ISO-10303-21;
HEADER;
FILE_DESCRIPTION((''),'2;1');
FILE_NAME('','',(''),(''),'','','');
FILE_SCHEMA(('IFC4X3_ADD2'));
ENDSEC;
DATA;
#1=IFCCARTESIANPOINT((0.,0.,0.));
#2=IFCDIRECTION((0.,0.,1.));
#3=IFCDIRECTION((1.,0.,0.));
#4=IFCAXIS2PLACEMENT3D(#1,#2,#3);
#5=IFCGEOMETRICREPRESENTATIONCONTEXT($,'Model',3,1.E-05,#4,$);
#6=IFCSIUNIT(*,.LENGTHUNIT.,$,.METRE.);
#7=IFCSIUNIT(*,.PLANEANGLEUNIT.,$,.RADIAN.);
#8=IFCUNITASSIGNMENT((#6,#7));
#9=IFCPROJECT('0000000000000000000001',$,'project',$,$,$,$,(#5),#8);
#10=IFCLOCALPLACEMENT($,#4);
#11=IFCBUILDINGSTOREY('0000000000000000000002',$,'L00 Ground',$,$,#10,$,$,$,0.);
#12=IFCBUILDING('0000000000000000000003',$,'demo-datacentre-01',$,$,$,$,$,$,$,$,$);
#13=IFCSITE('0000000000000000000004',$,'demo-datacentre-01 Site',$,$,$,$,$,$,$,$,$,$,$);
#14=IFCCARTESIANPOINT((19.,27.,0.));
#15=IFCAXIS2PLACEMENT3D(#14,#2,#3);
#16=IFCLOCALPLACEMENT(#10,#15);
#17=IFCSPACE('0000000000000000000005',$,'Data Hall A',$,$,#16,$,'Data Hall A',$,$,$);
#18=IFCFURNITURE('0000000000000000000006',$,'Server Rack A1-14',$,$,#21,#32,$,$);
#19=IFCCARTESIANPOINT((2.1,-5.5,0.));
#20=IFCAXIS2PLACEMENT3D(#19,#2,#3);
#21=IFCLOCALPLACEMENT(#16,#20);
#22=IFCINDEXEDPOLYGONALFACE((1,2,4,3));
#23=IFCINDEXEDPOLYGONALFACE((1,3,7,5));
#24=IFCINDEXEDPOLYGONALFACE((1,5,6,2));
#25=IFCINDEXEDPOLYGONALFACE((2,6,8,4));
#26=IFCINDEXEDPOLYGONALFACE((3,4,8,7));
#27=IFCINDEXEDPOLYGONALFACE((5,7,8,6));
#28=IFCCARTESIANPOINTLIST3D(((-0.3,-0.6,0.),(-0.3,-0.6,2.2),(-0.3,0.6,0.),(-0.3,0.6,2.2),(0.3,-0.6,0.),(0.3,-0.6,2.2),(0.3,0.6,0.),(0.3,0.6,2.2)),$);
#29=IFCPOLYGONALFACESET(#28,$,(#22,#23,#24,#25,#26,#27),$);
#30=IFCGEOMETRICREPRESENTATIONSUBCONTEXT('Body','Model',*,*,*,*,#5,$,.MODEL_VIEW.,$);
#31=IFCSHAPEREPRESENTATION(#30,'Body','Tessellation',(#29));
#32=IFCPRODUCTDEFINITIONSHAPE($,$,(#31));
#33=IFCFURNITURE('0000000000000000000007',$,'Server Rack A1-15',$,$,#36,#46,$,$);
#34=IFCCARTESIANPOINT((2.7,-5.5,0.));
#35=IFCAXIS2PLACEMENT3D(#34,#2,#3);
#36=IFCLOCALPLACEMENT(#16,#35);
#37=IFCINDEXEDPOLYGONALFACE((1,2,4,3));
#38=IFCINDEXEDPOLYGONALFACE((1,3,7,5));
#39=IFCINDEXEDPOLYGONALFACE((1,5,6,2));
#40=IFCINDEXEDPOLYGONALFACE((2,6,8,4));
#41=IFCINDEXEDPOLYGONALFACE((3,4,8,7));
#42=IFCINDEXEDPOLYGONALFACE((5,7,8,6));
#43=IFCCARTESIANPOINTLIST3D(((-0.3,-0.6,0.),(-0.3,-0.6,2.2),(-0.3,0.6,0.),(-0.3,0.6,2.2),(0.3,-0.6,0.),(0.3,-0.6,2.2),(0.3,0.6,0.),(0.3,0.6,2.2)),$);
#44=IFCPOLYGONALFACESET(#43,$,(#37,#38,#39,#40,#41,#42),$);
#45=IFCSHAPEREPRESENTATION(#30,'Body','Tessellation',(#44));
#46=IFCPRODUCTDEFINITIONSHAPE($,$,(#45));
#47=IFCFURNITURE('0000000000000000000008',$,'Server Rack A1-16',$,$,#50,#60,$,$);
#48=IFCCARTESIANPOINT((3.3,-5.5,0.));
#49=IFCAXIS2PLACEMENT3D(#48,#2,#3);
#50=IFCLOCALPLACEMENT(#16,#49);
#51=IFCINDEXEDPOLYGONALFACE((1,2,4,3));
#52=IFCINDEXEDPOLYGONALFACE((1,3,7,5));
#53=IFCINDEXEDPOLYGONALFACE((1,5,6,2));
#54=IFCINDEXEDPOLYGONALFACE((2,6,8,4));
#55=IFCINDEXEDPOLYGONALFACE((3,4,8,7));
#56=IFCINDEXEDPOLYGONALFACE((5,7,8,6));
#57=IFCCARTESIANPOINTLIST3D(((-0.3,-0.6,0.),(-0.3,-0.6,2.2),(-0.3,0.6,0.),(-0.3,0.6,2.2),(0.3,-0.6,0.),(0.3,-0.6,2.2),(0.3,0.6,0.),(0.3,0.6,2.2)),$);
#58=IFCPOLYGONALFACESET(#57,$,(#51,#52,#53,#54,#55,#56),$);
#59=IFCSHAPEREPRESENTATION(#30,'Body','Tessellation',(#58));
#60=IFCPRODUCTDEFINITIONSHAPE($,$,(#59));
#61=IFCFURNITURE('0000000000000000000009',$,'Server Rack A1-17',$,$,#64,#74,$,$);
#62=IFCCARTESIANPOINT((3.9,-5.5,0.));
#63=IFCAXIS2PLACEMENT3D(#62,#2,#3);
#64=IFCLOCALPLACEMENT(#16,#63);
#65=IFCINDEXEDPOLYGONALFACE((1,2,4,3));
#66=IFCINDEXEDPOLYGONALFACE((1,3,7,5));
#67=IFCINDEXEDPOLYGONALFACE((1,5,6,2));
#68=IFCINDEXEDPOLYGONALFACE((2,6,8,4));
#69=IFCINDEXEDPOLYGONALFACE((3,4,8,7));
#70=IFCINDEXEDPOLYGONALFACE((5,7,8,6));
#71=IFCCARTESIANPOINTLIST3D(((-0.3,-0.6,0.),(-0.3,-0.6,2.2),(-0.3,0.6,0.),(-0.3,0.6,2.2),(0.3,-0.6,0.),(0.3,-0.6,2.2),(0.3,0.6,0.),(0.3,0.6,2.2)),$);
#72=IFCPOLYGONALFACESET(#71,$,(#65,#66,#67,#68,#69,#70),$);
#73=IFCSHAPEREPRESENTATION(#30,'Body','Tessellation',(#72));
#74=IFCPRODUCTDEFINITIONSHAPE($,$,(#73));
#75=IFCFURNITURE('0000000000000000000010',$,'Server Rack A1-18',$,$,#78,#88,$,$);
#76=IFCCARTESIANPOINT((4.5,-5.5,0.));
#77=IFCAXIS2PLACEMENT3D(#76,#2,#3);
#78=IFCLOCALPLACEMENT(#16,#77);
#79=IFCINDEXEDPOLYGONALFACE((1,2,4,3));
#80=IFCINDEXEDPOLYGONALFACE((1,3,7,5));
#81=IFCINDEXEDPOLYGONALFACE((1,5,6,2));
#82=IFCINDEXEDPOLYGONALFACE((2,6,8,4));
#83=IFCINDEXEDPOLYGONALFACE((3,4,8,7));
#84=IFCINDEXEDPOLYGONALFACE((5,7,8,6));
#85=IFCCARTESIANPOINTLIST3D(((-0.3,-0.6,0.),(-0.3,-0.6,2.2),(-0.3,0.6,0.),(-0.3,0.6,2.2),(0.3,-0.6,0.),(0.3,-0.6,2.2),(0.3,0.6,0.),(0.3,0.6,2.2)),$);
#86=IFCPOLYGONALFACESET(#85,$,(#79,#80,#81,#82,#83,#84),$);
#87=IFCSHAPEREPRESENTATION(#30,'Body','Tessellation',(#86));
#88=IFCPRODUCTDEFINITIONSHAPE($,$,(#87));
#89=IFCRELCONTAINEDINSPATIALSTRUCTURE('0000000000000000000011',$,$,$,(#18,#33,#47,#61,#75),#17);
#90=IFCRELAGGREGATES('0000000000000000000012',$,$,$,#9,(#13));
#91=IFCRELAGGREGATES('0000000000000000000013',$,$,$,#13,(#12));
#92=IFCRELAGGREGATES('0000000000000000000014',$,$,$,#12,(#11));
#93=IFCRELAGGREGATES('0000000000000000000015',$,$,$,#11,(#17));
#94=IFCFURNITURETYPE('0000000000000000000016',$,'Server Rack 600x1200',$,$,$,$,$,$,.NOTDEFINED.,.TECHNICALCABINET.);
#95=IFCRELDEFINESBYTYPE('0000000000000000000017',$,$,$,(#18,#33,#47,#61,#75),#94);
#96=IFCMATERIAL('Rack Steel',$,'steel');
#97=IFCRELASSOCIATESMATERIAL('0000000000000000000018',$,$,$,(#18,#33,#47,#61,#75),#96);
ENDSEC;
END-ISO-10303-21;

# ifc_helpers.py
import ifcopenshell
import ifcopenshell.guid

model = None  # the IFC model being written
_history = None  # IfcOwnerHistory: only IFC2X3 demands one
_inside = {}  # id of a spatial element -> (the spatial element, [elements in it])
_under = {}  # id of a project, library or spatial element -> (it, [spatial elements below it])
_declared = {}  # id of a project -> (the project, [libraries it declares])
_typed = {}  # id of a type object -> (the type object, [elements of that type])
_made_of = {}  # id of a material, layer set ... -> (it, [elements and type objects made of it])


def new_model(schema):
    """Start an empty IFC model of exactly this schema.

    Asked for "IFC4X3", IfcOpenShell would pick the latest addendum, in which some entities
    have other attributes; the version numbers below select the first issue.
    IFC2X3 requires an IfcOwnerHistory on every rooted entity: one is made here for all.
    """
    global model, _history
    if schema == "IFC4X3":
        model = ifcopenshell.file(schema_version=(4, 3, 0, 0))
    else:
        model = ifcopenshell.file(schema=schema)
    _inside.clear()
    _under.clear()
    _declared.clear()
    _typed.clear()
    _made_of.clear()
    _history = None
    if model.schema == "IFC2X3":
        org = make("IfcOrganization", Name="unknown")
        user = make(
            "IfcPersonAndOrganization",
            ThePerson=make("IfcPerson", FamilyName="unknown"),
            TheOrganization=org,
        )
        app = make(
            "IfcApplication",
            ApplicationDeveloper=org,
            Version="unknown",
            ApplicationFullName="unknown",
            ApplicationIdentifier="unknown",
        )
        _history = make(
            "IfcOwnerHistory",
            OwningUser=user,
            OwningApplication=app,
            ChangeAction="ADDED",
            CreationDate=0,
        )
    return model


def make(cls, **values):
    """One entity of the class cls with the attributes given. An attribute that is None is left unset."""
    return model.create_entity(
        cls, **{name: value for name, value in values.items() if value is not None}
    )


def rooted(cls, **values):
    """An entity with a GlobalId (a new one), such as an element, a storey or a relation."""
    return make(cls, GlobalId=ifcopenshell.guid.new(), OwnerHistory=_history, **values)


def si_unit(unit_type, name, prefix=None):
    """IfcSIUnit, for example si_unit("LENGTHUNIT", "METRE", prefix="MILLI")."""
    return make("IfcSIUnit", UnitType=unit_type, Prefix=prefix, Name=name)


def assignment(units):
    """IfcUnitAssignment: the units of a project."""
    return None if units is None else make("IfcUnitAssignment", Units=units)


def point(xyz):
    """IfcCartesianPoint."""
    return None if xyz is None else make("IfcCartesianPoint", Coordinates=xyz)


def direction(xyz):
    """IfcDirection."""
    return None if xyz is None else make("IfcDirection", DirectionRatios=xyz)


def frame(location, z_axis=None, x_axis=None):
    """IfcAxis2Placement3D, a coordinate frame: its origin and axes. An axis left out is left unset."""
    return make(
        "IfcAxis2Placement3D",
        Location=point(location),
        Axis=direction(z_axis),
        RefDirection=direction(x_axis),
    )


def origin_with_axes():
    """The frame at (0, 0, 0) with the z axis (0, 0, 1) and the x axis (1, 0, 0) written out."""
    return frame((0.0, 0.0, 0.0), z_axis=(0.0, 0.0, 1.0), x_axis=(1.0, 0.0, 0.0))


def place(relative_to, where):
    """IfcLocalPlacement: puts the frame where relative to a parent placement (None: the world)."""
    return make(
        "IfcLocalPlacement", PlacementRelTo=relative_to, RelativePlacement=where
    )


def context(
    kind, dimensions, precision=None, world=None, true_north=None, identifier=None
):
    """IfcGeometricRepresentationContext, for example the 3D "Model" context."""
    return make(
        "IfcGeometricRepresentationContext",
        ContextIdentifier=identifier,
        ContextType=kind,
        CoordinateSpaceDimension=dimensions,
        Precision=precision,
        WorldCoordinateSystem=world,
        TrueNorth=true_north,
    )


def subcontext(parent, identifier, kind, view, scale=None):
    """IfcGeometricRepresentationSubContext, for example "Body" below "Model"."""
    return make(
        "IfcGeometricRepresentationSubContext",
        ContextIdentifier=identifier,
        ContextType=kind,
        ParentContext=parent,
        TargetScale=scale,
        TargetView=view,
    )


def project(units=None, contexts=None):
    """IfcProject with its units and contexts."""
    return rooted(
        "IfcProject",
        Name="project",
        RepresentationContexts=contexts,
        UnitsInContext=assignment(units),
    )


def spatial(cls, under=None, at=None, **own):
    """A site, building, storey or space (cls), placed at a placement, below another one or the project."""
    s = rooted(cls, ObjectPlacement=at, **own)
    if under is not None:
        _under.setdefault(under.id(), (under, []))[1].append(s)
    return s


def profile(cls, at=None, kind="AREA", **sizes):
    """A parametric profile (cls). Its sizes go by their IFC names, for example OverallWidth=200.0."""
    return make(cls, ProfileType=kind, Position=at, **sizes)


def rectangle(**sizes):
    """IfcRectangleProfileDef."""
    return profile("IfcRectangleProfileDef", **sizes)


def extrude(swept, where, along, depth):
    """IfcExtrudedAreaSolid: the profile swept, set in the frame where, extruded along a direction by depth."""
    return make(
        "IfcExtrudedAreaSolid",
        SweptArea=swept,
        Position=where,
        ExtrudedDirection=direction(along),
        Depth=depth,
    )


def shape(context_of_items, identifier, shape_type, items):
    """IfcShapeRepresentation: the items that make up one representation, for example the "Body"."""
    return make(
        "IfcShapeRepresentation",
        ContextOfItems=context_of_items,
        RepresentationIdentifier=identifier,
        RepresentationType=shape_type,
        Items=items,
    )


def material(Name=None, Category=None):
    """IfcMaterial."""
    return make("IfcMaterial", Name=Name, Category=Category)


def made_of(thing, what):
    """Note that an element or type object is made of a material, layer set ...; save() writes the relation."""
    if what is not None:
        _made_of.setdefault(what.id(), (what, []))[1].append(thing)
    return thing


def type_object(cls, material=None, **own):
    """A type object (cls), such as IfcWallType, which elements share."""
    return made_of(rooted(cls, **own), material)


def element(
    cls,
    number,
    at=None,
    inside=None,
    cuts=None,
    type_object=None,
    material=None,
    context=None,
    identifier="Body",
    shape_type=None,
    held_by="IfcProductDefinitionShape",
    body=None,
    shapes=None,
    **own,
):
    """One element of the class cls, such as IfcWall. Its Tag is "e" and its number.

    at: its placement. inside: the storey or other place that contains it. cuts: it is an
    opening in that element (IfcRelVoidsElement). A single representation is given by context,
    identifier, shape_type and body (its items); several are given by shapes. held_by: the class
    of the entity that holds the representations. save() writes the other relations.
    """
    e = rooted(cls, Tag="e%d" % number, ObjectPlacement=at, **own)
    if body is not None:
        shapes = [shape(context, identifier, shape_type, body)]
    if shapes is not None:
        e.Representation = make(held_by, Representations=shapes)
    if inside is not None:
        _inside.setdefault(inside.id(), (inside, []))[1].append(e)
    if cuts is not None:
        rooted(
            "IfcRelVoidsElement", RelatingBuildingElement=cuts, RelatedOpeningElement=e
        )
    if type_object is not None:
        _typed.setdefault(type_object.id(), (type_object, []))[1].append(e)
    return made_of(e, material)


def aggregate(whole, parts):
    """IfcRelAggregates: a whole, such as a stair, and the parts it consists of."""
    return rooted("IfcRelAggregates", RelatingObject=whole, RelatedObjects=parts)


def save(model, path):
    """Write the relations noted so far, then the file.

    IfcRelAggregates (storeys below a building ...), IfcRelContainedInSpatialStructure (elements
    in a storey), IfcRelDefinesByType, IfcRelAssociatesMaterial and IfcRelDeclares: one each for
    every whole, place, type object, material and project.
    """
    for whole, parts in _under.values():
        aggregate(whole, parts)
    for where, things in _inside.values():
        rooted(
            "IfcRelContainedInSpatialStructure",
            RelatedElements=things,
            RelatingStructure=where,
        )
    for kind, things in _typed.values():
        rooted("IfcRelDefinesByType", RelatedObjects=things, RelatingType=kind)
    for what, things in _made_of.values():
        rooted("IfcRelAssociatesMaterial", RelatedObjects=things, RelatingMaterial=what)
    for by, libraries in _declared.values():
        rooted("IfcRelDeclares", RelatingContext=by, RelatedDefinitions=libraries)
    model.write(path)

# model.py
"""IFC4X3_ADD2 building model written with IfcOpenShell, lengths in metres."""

from ifc_helpers import new_model, si_unit, frame, origin_with_axes, place, context, subcontext, project, spatial, rectangle, extrude, material, type_object, element, save


model = new_model("IFC4X3_ADD2")

# Units and contexts
model_context = context("Model", 3, precision=1e-05, world=origin_with_axes())
body_context = subcontext(model_context, "Body", "Model", "MODEL_VIEW")
ifc_project = project(units=[si_unit("LENGTHUNIT", "METRE"), si_unit("PLANEANGLEUNIT", "RADIAN")], contexts=[model_context])

# Site, building, storey
site = spatial("IfcSite", under=ifc_project, Name="demo-datacentre-01 Site")
building = spatial("IfcBuilding", under=site, Name="demo-datacentre-01")
storey_placement = place(None, origin_with_axes())
storey = spatial("IfcBuildingStorey", under=building, at=storey_placement, Name="L00 Ground", Elevation=0.0)

# Shared definitions
space_placement = place(storey_placement, frame((19.0, 27.0, 0.0), z_axis=(0.0, 0.0, 1.0), x_axis=(1.0, 0.0, 0.0)))
space = spatial("IfcSpace", under=storey, at=space_placement, Name="Data Hall A", LongName="Data Hall A")

# Furniture
ifc_material_1 = material(Name="Rack Steel", Category="steel")
furniture_type = type_object("IfcFurnitureType", Name="Server Rack 600x1200", AssemblyPlace="NOTDEFINED", PredefinedType="TECHNICALCABINET")
for number, where, z_axis, x_axis, name in (
    (1, (2.1, -5.5, 0.0), (0.0, 0.0, 1.0), (1.0, 0.0, 0.0), "Server Rack A1-14"),
    (2, (2.7, -5.5, 0.0), (0.0, 0.0, 1.0), (1.0, 0.0, 0.0), "Server Rack A1-15"),
    (3, (3.3, -5.5, 0.0), (0.0, 0.0, 1.0), (1.0, 0.0, 0.0), "Server Rack A1-16"),
    (4, (3.9, -5.5, 0.0), (0.0, 0.0, 1.0), (1.0, 0.0, 0.0), "Server Rack A1-17"),
    (5, (4.5, -5.5, 0.0), (0.0, 0.0, 1.0), (1.0, 0.0, 0.0), "Server Rack A1-18"),
):
    element("IfcFurniture", number, at=place(space_placement, frame(where, z_axis=z_axis, x_axis=x_axis)), inside=space, type_object=furniture_type, material=ifc_material_1, Name=name, context=body_context, shape_type="SweptSolid", body=[
        extrude(rectangle(XDim=0.6, YDim=1.2), origin_with_axes(), (0.0, 0.0, 1.0), 2.2),
    ])

save(model, "model.ifc")
